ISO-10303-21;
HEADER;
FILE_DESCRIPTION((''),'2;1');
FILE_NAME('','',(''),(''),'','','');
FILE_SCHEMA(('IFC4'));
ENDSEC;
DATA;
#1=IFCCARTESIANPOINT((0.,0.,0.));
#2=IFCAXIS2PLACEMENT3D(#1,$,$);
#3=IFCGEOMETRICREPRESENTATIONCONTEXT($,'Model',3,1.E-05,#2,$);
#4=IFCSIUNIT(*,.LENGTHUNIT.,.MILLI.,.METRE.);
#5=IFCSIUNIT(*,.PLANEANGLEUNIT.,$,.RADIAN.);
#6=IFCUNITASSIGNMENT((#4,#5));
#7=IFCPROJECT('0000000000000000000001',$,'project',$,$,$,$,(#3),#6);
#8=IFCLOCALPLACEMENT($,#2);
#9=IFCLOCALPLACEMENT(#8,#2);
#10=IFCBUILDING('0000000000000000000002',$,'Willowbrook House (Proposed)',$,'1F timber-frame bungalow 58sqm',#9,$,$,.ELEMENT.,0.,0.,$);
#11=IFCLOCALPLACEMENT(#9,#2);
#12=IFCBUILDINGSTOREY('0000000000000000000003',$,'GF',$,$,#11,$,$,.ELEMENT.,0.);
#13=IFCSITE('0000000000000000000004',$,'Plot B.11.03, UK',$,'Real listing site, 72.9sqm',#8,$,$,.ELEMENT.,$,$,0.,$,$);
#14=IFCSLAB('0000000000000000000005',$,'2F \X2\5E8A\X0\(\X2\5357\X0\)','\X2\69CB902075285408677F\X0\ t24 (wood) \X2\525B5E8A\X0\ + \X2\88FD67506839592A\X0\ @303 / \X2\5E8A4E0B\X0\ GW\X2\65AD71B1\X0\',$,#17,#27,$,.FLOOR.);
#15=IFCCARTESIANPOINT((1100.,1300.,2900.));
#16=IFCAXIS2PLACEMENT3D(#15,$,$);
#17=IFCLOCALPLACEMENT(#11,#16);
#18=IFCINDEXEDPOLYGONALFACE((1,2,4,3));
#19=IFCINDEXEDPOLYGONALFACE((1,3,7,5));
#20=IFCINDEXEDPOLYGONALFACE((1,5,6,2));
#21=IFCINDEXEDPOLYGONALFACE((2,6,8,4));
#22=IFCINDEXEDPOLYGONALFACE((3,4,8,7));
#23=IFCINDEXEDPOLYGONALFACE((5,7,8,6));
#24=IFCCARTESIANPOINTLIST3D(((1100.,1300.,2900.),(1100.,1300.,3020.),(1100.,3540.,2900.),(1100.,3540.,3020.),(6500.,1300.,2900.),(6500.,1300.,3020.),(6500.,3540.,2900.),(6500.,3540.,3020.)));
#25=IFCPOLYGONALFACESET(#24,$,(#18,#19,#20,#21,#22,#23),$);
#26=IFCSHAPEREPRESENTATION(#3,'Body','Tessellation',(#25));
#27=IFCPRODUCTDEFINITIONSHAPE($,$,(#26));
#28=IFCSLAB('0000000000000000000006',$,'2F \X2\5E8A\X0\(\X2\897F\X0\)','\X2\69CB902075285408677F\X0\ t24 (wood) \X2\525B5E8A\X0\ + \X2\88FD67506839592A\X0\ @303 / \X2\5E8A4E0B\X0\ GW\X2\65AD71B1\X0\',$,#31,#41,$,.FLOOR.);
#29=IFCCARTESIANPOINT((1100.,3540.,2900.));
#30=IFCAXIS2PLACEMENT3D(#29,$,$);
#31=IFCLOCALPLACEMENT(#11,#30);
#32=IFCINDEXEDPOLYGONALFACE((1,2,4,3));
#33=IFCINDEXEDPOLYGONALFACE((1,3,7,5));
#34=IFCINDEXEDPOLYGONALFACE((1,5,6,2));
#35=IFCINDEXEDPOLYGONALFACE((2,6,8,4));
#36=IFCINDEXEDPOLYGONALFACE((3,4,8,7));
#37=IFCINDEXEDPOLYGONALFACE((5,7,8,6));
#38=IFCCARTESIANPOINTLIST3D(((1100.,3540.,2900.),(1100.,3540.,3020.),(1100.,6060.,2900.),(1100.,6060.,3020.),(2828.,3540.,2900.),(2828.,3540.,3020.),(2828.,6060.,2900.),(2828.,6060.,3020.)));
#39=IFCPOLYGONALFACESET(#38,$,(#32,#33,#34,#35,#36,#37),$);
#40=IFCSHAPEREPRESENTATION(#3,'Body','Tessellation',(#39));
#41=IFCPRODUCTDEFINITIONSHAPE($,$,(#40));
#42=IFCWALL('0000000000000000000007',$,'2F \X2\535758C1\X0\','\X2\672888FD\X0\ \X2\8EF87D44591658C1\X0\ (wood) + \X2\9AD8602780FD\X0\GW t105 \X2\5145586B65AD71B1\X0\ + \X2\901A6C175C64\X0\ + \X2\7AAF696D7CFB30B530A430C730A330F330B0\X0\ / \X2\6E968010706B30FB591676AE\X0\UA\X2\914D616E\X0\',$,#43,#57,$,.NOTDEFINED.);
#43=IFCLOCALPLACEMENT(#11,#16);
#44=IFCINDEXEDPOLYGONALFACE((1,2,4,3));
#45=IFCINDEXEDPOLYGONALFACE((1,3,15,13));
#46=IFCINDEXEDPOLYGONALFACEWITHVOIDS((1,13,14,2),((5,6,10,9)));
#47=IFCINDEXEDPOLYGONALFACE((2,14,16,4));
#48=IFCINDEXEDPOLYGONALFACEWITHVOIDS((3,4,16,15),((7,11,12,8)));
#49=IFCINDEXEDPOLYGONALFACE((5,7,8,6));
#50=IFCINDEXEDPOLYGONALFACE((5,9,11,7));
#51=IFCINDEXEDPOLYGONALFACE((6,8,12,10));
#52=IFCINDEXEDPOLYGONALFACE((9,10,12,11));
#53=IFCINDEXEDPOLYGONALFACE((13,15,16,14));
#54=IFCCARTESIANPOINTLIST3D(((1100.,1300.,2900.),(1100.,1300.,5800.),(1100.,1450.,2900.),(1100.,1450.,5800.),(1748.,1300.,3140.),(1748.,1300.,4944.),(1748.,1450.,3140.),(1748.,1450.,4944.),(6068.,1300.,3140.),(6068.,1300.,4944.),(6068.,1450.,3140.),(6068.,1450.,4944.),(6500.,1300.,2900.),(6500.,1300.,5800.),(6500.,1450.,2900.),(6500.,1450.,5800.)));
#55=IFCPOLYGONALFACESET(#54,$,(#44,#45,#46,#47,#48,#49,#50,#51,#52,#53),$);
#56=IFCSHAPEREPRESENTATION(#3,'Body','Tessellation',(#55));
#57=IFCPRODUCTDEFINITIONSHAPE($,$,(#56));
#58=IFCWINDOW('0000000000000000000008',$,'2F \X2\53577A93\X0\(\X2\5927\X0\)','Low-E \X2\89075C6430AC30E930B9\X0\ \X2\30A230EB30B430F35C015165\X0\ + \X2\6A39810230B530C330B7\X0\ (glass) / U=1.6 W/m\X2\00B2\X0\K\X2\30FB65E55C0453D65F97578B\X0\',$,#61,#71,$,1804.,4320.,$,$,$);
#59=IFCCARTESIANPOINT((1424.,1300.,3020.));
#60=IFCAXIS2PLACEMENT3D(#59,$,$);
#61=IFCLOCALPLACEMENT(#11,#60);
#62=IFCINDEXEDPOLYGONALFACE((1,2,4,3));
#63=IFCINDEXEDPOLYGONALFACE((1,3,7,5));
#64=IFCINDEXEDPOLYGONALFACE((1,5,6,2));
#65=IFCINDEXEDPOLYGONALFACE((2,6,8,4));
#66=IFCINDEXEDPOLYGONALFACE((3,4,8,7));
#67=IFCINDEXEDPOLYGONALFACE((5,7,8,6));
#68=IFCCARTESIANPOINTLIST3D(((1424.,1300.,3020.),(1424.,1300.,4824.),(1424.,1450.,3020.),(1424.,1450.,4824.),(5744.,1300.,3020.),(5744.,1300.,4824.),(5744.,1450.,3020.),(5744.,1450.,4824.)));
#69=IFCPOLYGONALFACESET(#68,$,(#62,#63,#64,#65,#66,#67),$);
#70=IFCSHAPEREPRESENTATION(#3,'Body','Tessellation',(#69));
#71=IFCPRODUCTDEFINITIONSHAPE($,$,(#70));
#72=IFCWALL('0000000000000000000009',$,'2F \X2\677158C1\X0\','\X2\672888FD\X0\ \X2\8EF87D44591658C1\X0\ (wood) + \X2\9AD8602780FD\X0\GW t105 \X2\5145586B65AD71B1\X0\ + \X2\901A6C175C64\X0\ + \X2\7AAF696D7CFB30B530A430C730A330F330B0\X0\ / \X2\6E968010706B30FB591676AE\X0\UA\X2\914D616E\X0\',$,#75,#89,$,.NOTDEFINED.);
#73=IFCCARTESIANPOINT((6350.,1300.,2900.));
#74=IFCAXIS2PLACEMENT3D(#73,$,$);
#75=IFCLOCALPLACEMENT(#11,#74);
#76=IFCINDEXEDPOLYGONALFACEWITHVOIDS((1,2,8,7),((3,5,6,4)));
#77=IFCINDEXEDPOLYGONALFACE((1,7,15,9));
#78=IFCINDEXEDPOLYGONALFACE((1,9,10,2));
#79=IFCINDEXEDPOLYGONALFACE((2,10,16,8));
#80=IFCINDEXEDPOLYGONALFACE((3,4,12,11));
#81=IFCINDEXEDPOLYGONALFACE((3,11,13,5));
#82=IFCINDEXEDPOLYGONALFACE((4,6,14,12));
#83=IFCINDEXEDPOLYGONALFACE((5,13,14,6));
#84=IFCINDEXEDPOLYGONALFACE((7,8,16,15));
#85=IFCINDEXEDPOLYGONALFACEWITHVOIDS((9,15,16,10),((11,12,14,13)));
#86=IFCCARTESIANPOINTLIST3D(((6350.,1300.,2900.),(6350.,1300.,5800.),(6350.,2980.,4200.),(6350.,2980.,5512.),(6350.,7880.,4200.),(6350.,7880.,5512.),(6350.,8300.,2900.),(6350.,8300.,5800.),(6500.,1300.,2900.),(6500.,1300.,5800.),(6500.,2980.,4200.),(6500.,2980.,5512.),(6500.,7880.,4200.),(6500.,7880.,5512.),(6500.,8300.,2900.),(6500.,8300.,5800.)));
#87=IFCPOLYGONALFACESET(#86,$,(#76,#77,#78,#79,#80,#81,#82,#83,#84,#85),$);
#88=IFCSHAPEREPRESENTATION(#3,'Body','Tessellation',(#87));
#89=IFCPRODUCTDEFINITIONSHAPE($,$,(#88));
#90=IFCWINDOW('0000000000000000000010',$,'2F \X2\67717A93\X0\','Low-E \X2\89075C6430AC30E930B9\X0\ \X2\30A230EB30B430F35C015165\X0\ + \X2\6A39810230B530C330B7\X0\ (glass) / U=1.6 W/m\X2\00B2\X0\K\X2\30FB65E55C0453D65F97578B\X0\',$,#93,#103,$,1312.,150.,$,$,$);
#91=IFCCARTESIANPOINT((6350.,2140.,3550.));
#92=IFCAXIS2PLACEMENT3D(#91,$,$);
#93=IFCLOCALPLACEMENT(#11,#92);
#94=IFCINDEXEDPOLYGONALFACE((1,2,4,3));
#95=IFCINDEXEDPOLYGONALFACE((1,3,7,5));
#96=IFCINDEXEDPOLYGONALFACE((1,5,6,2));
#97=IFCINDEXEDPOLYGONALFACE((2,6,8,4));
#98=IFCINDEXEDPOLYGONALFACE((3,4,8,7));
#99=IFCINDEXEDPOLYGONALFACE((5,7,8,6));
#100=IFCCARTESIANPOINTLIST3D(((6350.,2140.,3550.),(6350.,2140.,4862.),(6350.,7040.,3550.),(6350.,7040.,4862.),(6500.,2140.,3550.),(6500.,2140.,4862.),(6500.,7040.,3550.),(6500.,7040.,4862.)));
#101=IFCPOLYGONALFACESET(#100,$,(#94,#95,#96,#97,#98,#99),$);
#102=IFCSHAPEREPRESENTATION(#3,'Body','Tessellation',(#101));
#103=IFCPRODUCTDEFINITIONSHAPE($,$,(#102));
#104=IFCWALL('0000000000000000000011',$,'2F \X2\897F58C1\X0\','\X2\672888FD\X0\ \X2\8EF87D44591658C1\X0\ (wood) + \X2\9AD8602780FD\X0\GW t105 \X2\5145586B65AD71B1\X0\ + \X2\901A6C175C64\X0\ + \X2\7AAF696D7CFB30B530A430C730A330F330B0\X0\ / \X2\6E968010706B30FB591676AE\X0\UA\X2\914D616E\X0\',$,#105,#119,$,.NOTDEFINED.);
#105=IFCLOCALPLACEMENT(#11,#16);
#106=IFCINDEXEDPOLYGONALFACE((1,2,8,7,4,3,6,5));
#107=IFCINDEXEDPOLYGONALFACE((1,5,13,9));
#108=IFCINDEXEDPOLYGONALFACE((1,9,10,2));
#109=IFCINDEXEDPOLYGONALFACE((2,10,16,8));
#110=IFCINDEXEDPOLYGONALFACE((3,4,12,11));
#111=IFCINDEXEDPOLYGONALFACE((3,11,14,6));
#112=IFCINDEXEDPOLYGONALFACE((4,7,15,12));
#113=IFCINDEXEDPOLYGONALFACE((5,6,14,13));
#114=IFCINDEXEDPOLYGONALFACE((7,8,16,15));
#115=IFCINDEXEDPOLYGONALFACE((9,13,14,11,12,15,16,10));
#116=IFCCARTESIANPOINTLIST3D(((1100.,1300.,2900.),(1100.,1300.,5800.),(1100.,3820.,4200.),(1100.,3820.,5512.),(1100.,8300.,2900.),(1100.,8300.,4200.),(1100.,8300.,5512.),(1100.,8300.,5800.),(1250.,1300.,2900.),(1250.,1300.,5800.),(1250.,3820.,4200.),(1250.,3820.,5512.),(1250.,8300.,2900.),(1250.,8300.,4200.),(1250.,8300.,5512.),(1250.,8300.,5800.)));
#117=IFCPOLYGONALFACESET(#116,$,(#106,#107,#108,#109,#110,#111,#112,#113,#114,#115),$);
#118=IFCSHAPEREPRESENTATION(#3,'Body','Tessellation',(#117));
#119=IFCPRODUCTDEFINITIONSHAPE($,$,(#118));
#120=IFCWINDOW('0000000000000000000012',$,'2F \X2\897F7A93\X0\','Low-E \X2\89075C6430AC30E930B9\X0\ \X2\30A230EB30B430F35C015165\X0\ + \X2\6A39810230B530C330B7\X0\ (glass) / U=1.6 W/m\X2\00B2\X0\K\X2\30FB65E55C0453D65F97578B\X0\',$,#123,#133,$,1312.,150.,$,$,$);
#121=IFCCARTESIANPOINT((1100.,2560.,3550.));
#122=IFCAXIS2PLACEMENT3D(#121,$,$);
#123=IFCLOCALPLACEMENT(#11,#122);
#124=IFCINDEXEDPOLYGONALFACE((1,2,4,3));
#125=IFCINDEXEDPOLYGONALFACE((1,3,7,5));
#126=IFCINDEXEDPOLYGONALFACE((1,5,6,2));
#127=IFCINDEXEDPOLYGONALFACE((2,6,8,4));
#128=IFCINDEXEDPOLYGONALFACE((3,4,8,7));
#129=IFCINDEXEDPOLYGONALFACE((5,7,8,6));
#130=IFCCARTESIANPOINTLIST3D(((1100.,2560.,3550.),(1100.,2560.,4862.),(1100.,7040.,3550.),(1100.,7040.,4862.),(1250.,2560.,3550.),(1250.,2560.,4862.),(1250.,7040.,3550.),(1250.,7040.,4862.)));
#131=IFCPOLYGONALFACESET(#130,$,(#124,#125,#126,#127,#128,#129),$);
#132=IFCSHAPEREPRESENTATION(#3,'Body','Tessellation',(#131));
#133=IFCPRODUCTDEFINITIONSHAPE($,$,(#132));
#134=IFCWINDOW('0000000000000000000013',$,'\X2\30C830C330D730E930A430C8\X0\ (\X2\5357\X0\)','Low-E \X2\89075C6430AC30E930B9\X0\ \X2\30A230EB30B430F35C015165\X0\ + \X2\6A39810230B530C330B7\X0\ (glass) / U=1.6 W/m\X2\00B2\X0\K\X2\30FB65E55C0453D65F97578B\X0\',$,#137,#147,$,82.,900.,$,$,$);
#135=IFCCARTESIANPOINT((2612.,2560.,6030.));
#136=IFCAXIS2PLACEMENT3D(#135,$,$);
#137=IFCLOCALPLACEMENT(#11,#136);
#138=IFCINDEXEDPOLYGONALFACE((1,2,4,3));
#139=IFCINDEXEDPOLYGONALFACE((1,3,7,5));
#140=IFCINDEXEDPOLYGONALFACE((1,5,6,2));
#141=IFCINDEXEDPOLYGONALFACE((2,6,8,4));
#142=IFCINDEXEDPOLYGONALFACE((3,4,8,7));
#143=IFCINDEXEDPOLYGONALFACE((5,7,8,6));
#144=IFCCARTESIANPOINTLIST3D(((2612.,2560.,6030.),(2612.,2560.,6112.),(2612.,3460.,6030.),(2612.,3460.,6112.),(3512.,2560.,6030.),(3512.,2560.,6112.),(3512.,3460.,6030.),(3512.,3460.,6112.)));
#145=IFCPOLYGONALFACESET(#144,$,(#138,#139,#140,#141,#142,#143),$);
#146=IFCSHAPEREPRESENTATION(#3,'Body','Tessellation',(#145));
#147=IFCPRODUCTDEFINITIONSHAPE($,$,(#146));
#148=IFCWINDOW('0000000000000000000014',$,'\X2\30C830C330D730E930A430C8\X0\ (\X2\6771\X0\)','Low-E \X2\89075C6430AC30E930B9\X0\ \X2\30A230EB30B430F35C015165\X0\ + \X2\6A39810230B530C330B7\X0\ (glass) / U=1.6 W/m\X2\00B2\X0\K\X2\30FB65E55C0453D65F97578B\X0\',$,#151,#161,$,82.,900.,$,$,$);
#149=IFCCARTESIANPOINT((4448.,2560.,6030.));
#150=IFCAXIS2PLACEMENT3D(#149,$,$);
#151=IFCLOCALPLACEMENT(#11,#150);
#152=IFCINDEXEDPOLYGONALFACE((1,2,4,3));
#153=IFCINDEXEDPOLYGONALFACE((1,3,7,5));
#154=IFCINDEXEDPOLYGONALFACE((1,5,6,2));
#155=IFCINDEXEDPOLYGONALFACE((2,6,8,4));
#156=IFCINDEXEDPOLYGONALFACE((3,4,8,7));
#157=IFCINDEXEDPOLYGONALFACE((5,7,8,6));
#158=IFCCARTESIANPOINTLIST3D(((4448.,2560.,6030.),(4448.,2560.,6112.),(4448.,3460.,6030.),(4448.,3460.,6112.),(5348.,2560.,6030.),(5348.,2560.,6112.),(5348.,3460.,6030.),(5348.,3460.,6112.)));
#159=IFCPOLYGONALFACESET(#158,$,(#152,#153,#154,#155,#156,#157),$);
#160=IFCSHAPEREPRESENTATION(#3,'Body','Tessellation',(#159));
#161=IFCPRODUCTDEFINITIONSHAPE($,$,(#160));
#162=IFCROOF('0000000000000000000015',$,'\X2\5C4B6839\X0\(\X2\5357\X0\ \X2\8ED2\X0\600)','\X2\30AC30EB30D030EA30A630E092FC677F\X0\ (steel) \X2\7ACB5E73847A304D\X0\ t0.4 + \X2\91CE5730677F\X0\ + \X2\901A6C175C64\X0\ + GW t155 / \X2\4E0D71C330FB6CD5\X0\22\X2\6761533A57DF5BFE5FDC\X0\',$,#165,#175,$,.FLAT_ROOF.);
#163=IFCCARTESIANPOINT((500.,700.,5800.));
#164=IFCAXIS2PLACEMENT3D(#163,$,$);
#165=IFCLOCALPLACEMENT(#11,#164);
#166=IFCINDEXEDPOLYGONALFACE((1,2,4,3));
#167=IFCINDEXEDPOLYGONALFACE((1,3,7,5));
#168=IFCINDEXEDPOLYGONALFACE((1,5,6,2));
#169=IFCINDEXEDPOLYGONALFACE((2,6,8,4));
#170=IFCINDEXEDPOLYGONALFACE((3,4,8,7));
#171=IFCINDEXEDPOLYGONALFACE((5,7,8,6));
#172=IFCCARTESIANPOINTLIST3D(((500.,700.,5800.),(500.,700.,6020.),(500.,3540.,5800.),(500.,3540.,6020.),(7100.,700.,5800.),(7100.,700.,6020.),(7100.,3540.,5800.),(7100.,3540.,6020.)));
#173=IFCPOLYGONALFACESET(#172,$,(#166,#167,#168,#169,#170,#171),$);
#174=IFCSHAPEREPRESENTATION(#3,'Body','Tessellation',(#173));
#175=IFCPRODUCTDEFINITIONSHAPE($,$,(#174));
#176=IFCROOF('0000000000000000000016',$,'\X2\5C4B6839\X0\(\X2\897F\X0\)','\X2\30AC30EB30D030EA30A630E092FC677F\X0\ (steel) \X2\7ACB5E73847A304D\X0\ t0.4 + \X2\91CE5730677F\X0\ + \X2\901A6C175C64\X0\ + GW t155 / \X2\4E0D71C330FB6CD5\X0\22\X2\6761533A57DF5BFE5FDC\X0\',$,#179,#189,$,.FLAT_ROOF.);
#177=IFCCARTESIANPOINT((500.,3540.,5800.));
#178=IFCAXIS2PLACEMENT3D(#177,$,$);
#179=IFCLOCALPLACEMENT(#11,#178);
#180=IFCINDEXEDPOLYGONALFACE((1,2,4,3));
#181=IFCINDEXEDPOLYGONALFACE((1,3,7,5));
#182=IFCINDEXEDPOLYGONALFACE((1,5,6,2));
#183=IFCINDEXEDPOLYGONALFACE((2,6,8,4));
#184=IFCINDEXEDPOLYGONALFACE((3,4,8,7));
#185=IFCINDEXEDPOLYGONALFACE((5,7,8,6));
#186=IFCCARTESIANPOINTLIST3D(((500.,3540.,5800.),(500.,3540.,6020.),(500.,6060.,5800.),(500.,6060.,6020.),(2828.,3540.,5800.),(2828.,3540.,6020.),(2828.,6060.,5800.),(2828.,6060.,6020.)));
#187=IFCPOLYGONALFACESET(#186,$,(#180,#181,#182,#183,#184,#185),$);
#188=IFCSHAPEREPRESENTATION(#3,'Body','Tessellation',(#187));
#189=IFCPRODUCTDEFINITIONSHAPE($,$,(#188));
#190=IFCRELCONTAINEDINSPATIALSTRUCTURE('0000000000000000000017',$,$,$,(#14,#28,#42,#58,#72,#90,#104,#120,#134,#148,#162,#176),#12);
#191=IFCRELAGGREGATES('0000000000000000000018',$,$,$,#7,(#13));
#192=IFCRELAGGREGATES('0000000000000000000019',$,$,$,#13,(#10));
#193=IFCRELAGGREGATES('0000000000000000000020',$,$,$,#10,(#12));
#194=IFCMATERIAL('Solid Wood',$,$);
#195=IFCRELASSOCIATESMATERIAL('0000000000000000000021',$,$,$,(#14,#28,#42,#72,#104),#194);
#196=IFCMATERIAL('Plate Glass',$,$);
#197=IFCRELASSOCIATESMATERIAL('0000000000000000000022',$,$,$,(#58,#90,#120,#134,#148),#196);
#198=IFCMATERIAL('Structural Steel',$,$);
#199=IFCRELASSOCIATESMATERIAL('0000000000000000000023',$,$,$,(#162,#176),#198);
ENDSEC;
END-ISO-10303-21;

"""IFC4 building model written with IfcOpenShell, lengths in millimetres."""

from ifc_helpers import new_model, si_unit, frame, frame_2d, origin, place, context, project, spatial, rectangle, extrude, material, element, fill, save


model = new_model("IFC4")

# Units and contexts
model_context = context("Model", 3, precision=1e-05, world=origin())
ifc_project = project(units=[si_unit("LENGTHUNIT", "METRE", prefix="MILLI"), si_unit("PLANEANGLEUNIT", "RADIAN")], contexts=[model_context])

# Site, building, storey
site_placement = place(None, origin())
site = spatial("IfcSite", under=ifc_project, at=site_placement, Name="Plot B.11.03, UK", ObjectType="Real listing site, 72.9sqm", CompositionType="ELEMENT", RefElevation=0.0)
building_placement = place(site_placement, origin())
building = spatial("IfcBuilding", under=site, at=building_placement, Name="Willowbrook House (Proposed)", ObjectType="1F timber-frame bungalow 58sqm", CompositionType="ELEMENT", ElevationOfRefHeight=0.0, ElevationOfTerrain=0.0)
storey_placement = place(building_placement, origin())
storey = spatial("IfcBuildingStorey", under=building, at=storey_placement, Name="GF", CompositionType="ELEMENT", Elevation=0.0)

# Slabs
ifc_material_1 = material(Name="Solid Wood")
slab_1_placement = place(storey_placement, frame((1100.0, 1300.0, 2900.0)))
element("IfcSlab", 1, at=slab_1_placement, inside=storey, material=ifc_material_1, Name="2F 床(南)", Description="構造用合板 t24 (wood) 剛床 + 製材根太 @303 / 床下 GW断熱", PredefinedType="FLOOR", context=model_context, shape_type="SweptSolid", body=[
    extrude(rectangle(XDim=5400.0, YDim=2240.0, at=frame_2d((2700.0, 1120.0))), frame((1100.0, 1300.0, 2900.0)), (0.0, 0.0, 1.0), 120.0),
])
slab_2_placement = place(storey_placement, frame((1100.0, 3540.0, 2900.0)))
element("IfcSlab", 2, at=slab_2_placement, inside=storey, material=ifc_material_1, Name="2F 床(西)", Description="構造用合板 t24 (wood) 剛床 + 製材根太 @303 / 床下 GW断熱", PredefinedType="FLOOR", context=model_context, shape_type="SweptSolid", body=[
    extrude(rectangle(XDim=1728.0, YDim=2520.0, at=frame_2d((864.0, 1260.0))), frame((1100.0, 3540.0, 2900.0)), (0.0, 0.0, 1.0), 120.0),
])

# Walls, openings, windows
wall_1_placement = place(storey_placement, frame((1100.0, 1300.0, 2900.0)))
wall_1 = element("IfcWall", 3, at=wall_1_placement, inside=storey, material=ifc_material_1, Name="2F 南壁", Description="木製 軸組外壁 (wood) + 高性能GW t105 充填断熱 + 通気層 + 窯業系サイディング / 準耐火・外皮UA配慮", PredefinedType="NOTDEFINED", context=model_context, shape_type="SweptSolid", body=[
    extrude(rectangle(XDim=5400.0, YDim=150.0, at=frame_2d((2700.0, 75.0))), frame((1100.0, 1300.0, 2900.0)), (0.0, 0.0, 1.0), 2900.0),
])
opening_1_placement = place(storey_placement, frame((1424.0, 1300.0, 3020.0)))
opening_1 = element("IfcOpeningElement", 4, at=opening_1_placement, cuts=wall_1, PredefinedType="NOTDEFINED", context=model_context, shape_type="SweptSolid", body=[
    extrude(rectangle(XDim=4320.0, YDim=150.0, at=frame_2d((2160.0, 75.0))), frame((1424.0, 1300.0, 3020.0)), (0.0, 0.0, 1.0), 1804.0),
])
ifc_material_2 = material(Name="Plate Glass")
window_1_placement = place(storey_placement, frame((1424.0, 1300.0, 3020.0)))
window_1 = element("IfcWindow", 5, at=window_1_placement, inside=storey, material=ifc_material_2, Name="2F 南窓(大)", Description="Low-E 複層ガラス アルゴン封入 + 樹脂サッシ (glass) / U=1.6 W/m²K・日射取得型", OverallHeight=1804.0, OverallWidth=4320.0, context=model_context, shape_type="SweptSolid", body=[
    extrude(rectangle(XDim=4320.0, YDim=150.0, at=frame_2d((2160.0, 75.0))), frame((1424.0, 1300.0, 3020.0)), (0.0, 0.0, 1.0), 1804.0),
])
fill(opening_1, window_1)
wall_2_placement = place(storey_placement, frame((6350.0, 1300.0, 2900.0)))
wall_2 = element("IfcWall", 6, at=wall_2_placement, inside=storey, material=ifc_material_1, Name="2F 東壁", Description="木製 軸組外壁 (wood) + 高性能GW t105 充填断熱 + 通気層 + 窯業系サイディング / 準耐火・外皮UA配慮", PredefinedType="NOTDEFINED", context=model_context, shape_type="SweptSolid", body=[
    extrude(rectangle(XDim=150.0, YDim=7000.0, at=frame_2d((75.0, 3500.0))), frame((6350.0, 1300.0, 2900.0)), (0.0, 0.0, 1.0), 2900.0),
])
opening_2_placement = place(storey_placement, frame((6350.0, 2140.0, 3550.0)))
opening_2 = element("IfcOpeningElement", 7, at=opening_2_placement, cuts=wall_2, PredefinedType="NOTDEFINED", context=model_context, shape_type="SweptSolid", body=[
    extrude(rectangle(XDim=150.0, YDim=4900.0, at=frame_2d((75.0, 2450.0))), frame((6350.0, 2140.0, 3550.0)), (0.0, 0.0, 1.0), 1312.0),
])
window_2_placement = place(storey_placement, frame((6350.0, 2140.0, 3550.0)))
window_2 = element("IfcWindow", 8, at=window_2_placement, inside=storey, material=ifc_material_2, Name="2F 東窓", Description="Low-E 複層ガラス アルゴン封入 + 樹脂サッシ (glass) / U=1.6 W/m²K・日射取得型", OverallHeight=1312.0, OverallWidth=150.0, context=model_context, shape_type="SweptSolid", body=[
    extrude(rectangle(XDim=150.0, YDim=4900.0, at=frame_2d((75.0, 2450.0))), frame((6350.0, 2140.0, 3550.0)), (0.0, 0.0, 1.0), 1312.0),
])
fill(opening_2, window_2)
wall_3_placement = place(storey_placement, frame((1100.0, 1300.0, 2900.0)))
wall_3 = element("IfcWall", 9, at=wall_3_placement, inside=storey, material=ifc_material_1, Name="2F 西壁", Description="木製 軸組外壁 (wood) + 高性能GW t105 充填断熱 + 通気層 + 窯業系サイディング / 準耐火・外皮UA配慮", PredefinedType="NOTDEFINED", context=model_context, shape_type="SweptSolid", body=[
    extrude(rectangle(XDim=150.0, YDim=7000.0, at=frame_2d((75.0, 3500.0))), frame((1100.0, 1300.0, 2900.0)), (0.0, 0.0, 1.0), 2900.0),
])
opening_3_placement = place(storey_placement, frame((1100.0, 2560.0, 3550.0)))
opening_3 = element("IfcOpeningElement", 10, at=opening_3_placement, cuts=wall_3, PredefinedType="NOTDEFINED", context=model_context, shape_type="SweptSolid", body=[
    extrude(rectangle(XDim=150.0, YDim=4480.0, at=frame_2d((75.0, 2240.0))), frame((1100.0, 2560.0, 3550.0)), (0.0, 0.0, 1.0), 1312.0),
])
window_3_placement = place(storey_placement, frame((1100.0, 2560.0, 3550.0)))
window_3 = element("IfcWindow", 11, at=window_3_placement, inside=storey, material=ifc_material_2, Name="2F 西窓", Description="Low-E 複層ガラス アルゴン封入 + 樹脂サッシ (glass) / U=1.6 W/m²K・日射取得型", OverallHeight=1312.0, OverallWidth=150.0, context=model_context, shape_type="SweptSolid", body=[
    extrude(rectangle(XDim=150.0, YDim=4480.0, at=frame_2d((75.0, 2240.0))), frame((1100.0, 2560.0, 3550.0)), (0.0, 0.0, 1.0), 1312.0),
])
fill(opening_3, window_3)

# Windows
window_4_placement = place(storey_placement, frame((2612.0, 2560.0, 6030.0)))
element("IfcWindow", 12, at=window_4_placement, inside=storey, material=ifc_material_2, Name="トップライト (南)", Description="Low-E 複層ガラス アルゴン封入 + 樹脂サッシ (glass) / U=1.6 W/m²K・日射取得型", OverallHeight=82.0, OverallWidth=900.0, context=model_context, shape_type="SweptSolid", body=[
    extrude(rectangle(XDim=900.0, YDim=900.0, at=frame_2d((450.0, 450.0))), frame((2612.0, 2560.0, 6030.0)), (0.0, 0.0, 1.0), 82.0),
])
window_5_placement = place(storey_placement, frame((4448.0, 2560.0, 6030.0)))
element("IfcWindow", 13, at=window_5_placement, inside=storey, material=ifc_material_2, Name="トップライト (東)", Description="Low-E 複層ガラス アルゴン封入 + 樹脂サッシ (glass) / U=1.6 W/m²K・日射取得型", OverallHeight=82.0, OverallWidth=900.0, context=model_context, shape_type="SweptSolid", body=[
    extrude(rectangle(XDim=900.0, YDim=900.0, at=frame_2d((450.0, 450.0))), frame((4448.0, 2560.0, 6030.0)), (0.0, 0.0, 1.0), 82.0),
])

# Roofs
ifc_material_3 = material(Name="Structural Steel")
roof_1_placement = place(storey_placement, frame((500.0, 700.0, 5800.0)))
element("IfcRoof", 14, at=roof_1_placement, inside=storey, material=ifc_material_3, Name="屋根(南 軒600)", Description="ガルバリウム鋼板 (steel) 立平葺き t0.4 + 野地板 + 通気層 + GW t155 / 不燃・法22条区域対応", PredefinedType="FLAT_ROOF", context=model_context, shape_type="SweptSolid", body=[
    extrude(rectangle(XDim=6600.0, YDim=2840.0, at=frame_2d((3300.0, 1420.0))), frame((500.0, 700.0, 5800.0)), (0.0, 0.0, 1.0), 220.0),
])
roof_2_placement = place(storey_placement, frame((500.0, 3540.0, 5800.0)))
element("IfcRoof", 15, at=roof_2_placement, inside=storey, material=ifc_material_3, Name="屋根(西)", Description="ガルバリウム鋼板 (steel) 立平葺き t0.4 + 野地板 + 通気層 + GW t155 / 不燃・法22条区域対応", PredefinedType="FLAT_ROOF", context=model_context, shape_type="SweptSolid", body=[
    extrude(rectangle(XDim=2328.0, YDim=2520.0, at=frame_2d((1164.0, 1260.0))), frame((500.0, 3540.0, 5800.0)), (0.0, 0.0, 1.0), 220.0),
])

save(model, "model.ifc")
